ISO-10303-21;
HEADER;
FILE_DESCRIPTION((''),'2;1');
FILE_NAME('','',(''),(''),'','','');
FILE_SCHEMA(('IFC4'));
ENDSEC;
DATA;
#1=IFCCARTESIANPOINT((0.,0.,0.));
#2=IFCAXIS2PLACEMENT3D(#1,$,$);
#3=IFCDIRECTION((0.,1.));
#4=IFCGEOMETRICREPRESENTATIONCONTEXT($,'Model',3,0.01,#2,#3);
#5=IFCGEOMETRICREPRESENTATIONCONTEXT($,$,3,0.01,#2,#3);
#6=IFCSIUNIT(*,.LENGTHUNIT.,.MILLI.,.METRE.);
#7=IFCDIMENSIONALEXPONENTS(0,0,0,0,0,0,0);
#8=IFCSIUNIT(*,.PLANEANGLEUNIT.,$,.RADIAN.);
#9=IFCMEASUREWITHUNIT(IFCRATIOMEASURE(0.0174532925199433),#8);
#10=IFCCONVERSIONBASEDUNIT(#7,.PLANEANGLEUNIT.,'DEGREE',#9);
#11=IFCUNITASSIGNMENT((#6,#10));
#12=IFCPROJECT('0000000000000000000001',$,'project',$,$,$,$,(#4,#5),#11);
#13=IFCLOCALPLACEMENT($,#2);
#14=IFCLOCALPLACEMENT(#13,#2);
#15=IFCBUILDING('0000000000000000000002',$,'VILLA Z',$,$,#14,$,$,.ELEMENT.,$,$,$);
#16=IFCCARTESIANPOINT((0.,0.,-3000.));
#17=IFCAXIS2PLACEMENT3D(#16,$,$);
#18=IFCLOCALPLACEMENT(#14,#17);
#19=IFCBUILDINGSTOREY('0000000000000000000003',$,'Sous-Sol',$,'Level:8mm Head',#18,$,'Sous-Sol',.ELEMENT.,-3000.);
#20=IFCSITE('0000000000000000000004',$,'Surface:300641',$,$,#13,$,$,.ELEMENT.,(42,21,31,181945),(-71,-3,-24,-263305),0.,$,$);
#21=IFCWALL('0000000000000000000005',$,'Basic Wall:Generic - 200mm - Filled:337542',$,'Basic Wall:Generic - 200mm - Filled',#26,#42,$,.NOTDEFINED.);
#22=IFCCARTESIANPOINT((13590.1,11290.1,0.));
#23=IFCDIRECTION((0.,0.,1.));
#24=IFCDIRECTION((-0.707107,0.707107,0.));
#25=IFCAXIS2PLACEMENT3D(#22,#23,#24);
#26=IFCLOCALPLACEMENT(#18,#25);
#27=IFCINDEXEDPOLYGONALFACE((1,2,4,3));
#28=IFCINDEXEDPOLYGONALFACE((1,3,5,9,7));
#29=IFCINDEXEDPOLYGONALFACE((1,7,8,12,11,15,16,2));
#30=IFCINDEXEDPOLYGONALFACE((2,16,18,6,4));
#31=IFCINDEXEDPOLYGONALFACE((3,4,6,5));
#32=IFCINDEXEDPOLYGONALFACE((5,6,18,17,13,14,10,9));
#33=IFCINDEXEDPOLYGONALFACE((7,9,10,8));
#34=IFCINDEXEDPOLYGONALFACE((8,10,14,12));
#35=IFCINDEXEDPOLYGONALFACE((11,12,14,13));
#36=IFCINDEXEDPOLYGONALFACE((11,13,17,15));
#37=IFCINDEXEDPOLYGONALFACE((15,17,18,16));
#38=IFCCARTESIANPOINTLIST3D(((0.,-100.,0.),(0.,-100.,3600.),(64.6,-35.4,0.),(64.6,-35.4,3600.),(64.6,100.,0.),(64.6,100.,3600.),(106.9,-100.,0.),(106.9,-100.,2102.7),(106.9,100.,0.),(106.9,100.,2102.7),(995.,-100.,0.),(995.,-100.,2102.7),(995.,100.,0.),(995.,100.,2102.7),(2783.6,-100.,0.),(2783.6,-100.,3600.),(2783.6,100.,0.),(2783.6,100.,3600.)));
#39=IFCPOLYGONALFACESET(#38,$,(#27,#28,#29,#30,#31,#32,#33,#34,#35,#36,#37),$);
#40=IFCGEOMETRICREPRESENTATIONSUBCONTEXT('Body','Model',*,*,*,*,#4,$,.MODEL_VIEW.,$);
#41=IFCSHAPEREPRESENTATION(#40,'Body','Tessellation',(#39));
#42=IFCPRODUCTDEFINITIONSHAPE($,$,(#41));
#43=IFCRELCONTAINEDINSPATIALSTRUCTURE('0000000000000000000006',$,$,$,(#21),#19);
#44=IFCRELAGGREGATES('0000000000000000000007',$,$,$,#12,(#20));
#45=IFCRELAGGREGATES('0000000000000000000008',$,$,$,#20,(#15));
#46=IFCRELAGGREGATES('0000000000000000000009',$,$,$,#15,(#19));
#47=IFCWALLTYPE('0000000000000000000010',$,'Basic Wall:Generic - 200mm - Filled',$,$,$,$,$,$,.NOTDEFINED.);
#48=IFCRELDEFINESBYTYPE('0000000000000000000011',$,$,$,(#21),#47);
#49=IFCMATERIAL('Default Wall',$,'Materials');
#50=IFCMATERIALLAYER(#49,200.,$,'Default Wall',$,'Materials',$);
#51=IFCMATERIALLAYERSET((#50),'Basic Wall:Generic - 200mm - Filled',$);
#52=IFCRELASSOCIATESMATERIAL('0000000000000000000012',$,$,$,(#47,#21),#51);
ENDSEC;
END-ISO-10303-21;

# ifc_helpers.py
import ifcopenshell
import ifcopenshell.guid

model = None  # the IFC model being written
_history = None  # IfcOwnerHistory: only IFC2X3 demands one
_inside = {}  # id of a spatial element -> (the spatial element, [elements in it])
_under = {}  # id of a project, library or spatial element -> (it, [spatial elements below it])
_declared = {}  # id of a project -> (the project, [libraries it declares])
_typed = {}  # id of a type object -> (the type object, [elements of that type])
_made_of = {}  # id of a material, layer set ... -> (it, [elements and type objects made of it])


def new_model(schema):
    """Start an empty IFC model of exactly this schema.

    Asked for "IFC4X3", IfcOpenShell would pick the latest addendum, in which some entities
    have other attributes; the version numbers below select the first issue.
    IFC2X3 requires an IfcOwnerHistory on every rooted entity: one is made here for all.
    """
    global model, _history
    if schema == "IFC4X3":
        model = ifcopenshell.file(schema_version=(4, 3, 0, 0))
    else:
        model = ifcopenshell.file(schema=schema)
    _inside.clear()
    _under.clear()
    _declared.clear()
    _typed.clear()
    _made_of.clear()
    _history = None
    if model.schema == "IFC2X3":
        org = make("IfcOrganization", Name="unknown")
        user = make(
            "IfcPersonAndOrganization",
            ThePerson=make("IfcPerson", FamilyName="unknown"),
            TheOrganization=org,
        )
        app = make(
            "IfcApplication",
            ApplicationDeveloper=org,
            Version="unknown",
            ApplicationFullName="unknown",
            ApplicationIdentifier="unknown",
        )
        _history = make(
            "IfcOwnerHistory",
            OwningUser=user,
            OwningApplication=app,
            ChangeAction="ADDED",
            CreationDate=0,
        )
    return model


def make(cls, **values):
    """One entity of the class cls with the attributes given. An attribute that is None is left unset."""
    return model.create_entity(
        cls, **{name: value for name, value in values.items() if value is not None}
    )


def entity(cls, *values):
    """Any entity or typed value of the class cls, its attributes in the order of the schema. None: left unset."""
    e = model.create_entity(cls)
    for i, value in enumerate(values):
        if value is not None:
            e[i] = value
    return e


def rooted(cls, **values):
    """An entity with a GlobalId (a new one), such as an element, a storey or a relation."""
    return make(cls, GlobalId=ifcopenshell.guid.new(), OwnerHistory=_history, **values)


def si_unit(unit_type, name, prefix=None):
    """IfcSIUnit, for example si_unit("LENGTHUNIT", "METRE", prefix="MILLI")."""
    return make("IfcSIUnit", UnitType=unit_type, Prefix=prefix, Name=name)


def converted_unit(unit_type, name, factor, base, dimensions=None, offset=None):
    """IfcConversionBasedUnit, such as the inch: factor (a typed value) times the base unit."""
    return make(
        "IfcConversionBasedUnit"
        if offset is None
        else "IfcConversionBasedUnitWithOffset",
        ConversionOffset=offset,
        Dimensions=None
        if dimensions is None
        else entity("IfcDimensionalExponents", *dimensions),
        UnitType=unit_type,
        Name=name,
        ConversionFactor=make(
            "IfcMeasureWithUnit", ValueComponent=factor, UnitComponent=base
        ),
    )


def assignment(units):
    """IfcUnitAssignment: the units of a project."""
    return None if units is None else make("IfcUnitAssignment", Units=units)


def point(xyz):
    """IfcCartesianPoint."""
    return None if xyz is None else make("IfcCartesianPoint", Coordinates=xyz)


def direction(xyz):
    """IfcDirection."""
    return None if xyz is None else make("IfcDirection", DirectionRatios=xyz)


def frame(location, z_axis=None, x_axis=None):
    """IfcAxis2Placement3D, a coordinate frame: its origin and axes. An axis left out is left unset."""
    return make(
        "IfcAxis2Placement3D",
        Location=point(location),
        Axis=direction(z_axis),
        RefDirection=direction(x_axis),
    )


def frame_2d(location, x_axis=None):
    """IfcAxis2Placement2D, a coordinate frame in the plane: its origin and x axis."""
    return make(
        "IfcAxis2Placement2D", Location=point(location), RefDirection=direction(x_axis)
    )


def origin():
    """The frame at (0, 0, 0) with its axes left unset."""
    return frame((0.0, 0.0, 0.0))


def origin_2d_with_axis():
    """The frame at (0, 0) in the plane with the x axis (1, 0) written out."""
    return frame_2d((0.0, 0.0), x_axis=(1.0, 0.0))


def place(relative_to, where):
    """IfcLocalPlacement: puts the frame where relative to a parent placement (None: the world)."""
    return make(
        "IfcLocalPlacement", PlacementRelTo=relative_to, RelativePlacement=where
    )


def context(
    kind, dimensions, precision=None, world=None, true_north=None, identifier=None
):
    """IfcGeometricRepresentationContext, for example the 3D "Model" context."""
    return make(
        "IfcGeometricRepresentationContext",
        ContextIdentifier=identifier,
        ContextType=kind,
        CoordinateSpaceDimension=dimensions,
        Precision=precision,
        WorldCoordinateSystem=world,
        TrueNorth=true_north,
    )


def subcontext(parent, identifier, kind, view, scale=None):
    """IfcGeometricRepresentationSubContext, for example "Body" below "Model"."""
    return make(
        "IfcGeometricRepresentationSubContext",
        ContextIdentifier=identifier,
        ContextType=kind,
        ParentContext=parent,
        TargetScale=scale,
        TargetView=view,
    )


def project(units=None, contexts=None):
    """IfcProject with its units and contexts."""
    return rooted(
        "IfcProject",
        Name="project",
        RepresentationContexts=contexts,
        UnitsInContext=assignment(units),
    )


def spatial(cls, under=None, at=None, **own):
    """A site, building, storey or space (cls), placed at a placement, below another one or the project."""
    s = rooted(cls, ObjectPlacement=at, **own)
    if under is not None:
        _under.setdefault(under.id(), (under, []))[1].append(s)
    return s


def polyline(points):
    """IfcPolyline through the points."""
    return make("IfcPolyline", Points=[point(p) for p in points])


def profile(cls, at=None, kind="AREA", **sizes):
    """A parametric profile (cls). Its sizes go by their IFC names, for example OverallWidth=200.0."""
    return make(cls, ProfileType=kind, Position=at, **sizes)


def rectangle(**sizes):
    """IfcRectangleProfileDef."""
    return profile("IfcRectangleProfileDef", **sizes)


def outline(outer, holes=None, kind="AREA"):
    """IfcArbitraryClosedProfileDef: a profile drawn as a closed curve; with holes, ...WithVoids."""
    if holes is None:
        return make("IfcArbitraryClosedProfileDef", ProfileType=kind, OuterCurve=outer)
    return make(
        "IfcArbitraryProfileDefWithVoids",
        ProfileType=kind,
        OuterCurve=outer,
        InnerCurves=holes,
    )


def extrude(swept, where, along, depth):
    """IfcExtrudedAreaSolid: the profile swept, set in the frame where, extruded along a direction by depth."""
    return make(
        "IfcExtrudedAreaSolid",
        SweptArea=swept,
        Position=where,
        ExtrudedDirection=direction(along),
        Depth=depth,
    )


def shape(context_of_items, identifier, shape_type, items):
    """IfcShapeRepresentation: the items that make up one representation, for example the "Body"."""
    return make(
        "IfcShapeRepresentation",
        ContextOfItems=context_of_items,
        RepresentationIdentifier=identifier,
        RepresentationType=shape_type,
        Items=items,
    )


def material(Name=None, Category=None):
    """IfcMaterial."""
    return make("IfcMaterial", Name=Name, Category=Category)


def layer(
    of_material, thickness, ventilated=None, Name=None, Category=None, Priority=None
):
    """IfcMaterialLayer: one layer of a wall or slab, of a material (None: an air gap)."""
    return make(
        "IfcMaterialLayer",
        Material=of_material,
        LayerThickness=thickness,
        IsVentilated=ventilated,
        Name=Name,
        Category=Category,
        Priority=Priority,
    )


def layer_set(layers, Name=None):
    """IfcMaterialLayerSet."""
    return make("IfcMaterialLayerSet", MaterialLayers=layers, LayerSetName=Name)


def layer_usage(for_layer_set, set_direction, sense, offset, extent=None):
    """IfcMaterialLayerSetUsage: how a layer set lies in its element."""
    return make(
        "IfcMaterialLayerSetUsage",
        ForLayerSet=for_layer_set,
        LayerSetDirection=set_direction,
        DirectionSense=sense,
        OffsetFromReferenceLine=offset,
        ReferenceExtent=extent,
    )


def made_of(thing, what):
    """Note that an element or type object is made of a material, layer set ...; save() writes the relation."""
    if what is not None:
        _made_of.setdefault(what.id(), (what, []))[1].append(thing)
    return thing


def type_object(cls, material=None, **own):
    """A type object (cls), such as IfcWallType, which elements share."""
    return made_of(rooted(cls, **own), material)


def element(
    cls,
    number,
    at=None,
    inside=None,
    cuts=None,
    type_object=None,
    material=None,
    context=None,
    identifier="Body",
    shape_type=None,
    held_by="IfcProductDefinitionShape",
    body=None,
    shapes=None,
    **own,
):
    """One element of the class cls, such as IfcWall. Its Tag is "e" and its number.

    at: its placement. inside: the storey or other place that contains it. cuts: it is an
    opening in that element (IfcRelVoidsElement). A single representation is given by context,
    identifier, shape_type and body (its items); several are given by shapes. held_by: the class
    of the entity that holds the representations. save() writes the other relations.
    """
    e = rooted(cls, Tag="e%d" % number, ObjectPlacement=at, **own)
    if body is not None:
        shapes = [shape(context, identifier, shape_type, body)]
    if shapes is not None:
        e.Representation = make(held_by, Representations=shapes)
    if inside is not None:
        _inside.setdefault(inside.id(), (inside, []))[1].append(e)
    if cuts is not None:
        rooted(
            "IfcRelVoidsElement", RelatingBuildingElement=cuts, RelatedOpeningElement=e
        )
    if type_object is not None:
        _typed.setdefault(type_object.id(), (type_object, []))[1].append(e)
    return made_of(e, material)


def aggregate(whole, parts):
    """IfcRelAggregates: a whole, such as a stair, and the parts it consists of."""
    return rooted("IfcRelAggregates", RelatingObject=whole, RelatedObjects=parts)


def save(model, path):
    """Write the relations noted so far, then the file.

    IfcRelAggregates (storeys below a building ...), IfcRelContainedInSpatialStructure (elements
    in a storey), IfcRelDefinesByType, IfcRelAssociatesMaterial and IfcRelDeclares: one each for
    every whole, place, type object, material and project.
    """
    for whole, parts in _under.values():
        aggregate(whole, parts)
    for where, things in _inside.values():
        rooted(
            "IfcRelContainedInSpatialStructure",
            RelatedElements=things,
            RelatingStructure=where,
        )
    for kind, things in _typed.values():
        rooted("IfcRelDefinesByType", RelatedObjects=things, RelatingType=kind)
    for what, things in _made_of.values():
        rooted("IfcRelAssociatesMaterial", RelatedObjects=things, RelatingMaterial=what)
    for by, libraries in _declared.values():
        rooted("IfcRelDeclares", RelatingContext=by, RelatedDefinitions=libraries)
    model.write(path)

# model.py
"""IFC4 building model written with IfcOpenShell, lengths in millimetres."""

from ifc_helpers import new_model, entity, si_unit, converted_unit, direction, frame, origin, origin_2d_with_axis, place, context, subcontext, project, spatial, polyline, rectangle, outline, extrude, material, layer, layer_set, layer_usage, type_object, element, save


model = new_model("IFC4")

# Units and contexts
model_context = context("Model", 3, precision=0.01, world=origin(), true_north=direction((0.0, 1.0)))
context_of_model = context(None, 3, precision=0.01, world=origin(), true_north=direction((0.0, 1.0)))
body_context = subcontext(model_context, "Body", "Model", "MODEL_VIEW")
ifc_project = project(units=[si_unit("LENGTHUNIT", "METRE", prefix="MILLI"), converted_unit("PLANEANGLEUNIT", "DEGREE", entity("IfcRatioMeasure", 0.0174532925199433), si_unit("PLANEANGLEUNIT", "RADIAN"), dimensions=[0, 0, 0, 0, 0, 0, 0])], contexts=[model_context, context_of_model])

# Site, building, storey
site_placement = place(None, origin())
site = spatial("IfcSite", under=ifc_project, at=site_placement, Name="Surface:300641", CompositionType="ELEMENT", RefLatitude=(42, 21, 31, 181945), RefLongitude=(-71, -3, -24, -263305), RefElevation=0.0)
building_placement = place(site_placement, origin())
building = spatial("IfcBuilding", under=site, at=building_placement, Name="VILLA Z", CompositionType="ELEMENT")
storey_placement = place(building_placement, frame((0.0, 0.0, -3000.0)))
storey = spatial("IfcBuildingStorey", under=building, at=storey_placement, Name="Sous-Sol", ObjectType="Level:8mm Head", LongName="Sous-Sol", CompositionType="ELEMENT", Elevation=-3000.0)

# Shared definitions
ifc_material_1 = material(Name="Default Wall", Category="Materials")

# Wall, opening
ifc_layer_1 = layer(ifc_material_1, 200.0, Name="Default Wall", Category="Materials")
ifc_layer_set_1 = layer_set([ifc_layer_1], Name="Basic Wall:Generic - 200mm - Filled")
ifc_layer_usage_1 = layer_usage(ifc_layer_set_1, "AXIS2", "NEGATIVE", 100.0)
wall_type_1 = type_object("IfcWallType", Name="Basic Wall:Generic - 200mm - Filled", PredefinedType="NOTDEFINED", material=ifc_layer_set_1)
wall_1_placement = place(storey_placement, frame((13590.1, 11290.1, 0.0), z_axis=(0.0, 0.0, 1.0), x_axis=(-0.707107, 0.707107, 0.0)))
wall_1 = element("IfcWall", 1, at=wall_1_placement, inside=storey, type_object=wall_type_1, material=ifc_layer_usage_1, Name="Basic Wall:Generic - 200mm - Filled:337542", ObjectType="Basic Wall:Generic - 200mm - Filled", PredefinedType="NOTDEFINED", context=body_context, shape_type="SweptSolid", body=[
    extrude(outline(polyline([(0.0, -100.0), (2783.6, -100.0), (2783.6, 100.0), (64.6, 100.0), (64.6, -35.4), (0.0, -100.0)])), origin(), (0.0, 0.0, 1.0), 3600.0),
])
opening_1_placement = place(wall_1_placement, frame((550.9, 544.0, -28.3)))
element("IfcOpeningElement", 2, at=opening_1_placement, cuts=wall_1, ObjectType="Opening", PredefinedType="OPENING", context=body_context, shape_type="SweptSolid", body=[
    extrude(rectangle(XDim=2131.0, YDim=888.1, at=origin_2d_with_axis()), frame((0.0, -644.0, 1065.5), z_axis=(0.0, 1.0, 0.0), x_axis=(0.0, 0.0, -1.0)), (0.0, 0.0, 1.0), 200.0),
])

save(model, "model.ifc")
